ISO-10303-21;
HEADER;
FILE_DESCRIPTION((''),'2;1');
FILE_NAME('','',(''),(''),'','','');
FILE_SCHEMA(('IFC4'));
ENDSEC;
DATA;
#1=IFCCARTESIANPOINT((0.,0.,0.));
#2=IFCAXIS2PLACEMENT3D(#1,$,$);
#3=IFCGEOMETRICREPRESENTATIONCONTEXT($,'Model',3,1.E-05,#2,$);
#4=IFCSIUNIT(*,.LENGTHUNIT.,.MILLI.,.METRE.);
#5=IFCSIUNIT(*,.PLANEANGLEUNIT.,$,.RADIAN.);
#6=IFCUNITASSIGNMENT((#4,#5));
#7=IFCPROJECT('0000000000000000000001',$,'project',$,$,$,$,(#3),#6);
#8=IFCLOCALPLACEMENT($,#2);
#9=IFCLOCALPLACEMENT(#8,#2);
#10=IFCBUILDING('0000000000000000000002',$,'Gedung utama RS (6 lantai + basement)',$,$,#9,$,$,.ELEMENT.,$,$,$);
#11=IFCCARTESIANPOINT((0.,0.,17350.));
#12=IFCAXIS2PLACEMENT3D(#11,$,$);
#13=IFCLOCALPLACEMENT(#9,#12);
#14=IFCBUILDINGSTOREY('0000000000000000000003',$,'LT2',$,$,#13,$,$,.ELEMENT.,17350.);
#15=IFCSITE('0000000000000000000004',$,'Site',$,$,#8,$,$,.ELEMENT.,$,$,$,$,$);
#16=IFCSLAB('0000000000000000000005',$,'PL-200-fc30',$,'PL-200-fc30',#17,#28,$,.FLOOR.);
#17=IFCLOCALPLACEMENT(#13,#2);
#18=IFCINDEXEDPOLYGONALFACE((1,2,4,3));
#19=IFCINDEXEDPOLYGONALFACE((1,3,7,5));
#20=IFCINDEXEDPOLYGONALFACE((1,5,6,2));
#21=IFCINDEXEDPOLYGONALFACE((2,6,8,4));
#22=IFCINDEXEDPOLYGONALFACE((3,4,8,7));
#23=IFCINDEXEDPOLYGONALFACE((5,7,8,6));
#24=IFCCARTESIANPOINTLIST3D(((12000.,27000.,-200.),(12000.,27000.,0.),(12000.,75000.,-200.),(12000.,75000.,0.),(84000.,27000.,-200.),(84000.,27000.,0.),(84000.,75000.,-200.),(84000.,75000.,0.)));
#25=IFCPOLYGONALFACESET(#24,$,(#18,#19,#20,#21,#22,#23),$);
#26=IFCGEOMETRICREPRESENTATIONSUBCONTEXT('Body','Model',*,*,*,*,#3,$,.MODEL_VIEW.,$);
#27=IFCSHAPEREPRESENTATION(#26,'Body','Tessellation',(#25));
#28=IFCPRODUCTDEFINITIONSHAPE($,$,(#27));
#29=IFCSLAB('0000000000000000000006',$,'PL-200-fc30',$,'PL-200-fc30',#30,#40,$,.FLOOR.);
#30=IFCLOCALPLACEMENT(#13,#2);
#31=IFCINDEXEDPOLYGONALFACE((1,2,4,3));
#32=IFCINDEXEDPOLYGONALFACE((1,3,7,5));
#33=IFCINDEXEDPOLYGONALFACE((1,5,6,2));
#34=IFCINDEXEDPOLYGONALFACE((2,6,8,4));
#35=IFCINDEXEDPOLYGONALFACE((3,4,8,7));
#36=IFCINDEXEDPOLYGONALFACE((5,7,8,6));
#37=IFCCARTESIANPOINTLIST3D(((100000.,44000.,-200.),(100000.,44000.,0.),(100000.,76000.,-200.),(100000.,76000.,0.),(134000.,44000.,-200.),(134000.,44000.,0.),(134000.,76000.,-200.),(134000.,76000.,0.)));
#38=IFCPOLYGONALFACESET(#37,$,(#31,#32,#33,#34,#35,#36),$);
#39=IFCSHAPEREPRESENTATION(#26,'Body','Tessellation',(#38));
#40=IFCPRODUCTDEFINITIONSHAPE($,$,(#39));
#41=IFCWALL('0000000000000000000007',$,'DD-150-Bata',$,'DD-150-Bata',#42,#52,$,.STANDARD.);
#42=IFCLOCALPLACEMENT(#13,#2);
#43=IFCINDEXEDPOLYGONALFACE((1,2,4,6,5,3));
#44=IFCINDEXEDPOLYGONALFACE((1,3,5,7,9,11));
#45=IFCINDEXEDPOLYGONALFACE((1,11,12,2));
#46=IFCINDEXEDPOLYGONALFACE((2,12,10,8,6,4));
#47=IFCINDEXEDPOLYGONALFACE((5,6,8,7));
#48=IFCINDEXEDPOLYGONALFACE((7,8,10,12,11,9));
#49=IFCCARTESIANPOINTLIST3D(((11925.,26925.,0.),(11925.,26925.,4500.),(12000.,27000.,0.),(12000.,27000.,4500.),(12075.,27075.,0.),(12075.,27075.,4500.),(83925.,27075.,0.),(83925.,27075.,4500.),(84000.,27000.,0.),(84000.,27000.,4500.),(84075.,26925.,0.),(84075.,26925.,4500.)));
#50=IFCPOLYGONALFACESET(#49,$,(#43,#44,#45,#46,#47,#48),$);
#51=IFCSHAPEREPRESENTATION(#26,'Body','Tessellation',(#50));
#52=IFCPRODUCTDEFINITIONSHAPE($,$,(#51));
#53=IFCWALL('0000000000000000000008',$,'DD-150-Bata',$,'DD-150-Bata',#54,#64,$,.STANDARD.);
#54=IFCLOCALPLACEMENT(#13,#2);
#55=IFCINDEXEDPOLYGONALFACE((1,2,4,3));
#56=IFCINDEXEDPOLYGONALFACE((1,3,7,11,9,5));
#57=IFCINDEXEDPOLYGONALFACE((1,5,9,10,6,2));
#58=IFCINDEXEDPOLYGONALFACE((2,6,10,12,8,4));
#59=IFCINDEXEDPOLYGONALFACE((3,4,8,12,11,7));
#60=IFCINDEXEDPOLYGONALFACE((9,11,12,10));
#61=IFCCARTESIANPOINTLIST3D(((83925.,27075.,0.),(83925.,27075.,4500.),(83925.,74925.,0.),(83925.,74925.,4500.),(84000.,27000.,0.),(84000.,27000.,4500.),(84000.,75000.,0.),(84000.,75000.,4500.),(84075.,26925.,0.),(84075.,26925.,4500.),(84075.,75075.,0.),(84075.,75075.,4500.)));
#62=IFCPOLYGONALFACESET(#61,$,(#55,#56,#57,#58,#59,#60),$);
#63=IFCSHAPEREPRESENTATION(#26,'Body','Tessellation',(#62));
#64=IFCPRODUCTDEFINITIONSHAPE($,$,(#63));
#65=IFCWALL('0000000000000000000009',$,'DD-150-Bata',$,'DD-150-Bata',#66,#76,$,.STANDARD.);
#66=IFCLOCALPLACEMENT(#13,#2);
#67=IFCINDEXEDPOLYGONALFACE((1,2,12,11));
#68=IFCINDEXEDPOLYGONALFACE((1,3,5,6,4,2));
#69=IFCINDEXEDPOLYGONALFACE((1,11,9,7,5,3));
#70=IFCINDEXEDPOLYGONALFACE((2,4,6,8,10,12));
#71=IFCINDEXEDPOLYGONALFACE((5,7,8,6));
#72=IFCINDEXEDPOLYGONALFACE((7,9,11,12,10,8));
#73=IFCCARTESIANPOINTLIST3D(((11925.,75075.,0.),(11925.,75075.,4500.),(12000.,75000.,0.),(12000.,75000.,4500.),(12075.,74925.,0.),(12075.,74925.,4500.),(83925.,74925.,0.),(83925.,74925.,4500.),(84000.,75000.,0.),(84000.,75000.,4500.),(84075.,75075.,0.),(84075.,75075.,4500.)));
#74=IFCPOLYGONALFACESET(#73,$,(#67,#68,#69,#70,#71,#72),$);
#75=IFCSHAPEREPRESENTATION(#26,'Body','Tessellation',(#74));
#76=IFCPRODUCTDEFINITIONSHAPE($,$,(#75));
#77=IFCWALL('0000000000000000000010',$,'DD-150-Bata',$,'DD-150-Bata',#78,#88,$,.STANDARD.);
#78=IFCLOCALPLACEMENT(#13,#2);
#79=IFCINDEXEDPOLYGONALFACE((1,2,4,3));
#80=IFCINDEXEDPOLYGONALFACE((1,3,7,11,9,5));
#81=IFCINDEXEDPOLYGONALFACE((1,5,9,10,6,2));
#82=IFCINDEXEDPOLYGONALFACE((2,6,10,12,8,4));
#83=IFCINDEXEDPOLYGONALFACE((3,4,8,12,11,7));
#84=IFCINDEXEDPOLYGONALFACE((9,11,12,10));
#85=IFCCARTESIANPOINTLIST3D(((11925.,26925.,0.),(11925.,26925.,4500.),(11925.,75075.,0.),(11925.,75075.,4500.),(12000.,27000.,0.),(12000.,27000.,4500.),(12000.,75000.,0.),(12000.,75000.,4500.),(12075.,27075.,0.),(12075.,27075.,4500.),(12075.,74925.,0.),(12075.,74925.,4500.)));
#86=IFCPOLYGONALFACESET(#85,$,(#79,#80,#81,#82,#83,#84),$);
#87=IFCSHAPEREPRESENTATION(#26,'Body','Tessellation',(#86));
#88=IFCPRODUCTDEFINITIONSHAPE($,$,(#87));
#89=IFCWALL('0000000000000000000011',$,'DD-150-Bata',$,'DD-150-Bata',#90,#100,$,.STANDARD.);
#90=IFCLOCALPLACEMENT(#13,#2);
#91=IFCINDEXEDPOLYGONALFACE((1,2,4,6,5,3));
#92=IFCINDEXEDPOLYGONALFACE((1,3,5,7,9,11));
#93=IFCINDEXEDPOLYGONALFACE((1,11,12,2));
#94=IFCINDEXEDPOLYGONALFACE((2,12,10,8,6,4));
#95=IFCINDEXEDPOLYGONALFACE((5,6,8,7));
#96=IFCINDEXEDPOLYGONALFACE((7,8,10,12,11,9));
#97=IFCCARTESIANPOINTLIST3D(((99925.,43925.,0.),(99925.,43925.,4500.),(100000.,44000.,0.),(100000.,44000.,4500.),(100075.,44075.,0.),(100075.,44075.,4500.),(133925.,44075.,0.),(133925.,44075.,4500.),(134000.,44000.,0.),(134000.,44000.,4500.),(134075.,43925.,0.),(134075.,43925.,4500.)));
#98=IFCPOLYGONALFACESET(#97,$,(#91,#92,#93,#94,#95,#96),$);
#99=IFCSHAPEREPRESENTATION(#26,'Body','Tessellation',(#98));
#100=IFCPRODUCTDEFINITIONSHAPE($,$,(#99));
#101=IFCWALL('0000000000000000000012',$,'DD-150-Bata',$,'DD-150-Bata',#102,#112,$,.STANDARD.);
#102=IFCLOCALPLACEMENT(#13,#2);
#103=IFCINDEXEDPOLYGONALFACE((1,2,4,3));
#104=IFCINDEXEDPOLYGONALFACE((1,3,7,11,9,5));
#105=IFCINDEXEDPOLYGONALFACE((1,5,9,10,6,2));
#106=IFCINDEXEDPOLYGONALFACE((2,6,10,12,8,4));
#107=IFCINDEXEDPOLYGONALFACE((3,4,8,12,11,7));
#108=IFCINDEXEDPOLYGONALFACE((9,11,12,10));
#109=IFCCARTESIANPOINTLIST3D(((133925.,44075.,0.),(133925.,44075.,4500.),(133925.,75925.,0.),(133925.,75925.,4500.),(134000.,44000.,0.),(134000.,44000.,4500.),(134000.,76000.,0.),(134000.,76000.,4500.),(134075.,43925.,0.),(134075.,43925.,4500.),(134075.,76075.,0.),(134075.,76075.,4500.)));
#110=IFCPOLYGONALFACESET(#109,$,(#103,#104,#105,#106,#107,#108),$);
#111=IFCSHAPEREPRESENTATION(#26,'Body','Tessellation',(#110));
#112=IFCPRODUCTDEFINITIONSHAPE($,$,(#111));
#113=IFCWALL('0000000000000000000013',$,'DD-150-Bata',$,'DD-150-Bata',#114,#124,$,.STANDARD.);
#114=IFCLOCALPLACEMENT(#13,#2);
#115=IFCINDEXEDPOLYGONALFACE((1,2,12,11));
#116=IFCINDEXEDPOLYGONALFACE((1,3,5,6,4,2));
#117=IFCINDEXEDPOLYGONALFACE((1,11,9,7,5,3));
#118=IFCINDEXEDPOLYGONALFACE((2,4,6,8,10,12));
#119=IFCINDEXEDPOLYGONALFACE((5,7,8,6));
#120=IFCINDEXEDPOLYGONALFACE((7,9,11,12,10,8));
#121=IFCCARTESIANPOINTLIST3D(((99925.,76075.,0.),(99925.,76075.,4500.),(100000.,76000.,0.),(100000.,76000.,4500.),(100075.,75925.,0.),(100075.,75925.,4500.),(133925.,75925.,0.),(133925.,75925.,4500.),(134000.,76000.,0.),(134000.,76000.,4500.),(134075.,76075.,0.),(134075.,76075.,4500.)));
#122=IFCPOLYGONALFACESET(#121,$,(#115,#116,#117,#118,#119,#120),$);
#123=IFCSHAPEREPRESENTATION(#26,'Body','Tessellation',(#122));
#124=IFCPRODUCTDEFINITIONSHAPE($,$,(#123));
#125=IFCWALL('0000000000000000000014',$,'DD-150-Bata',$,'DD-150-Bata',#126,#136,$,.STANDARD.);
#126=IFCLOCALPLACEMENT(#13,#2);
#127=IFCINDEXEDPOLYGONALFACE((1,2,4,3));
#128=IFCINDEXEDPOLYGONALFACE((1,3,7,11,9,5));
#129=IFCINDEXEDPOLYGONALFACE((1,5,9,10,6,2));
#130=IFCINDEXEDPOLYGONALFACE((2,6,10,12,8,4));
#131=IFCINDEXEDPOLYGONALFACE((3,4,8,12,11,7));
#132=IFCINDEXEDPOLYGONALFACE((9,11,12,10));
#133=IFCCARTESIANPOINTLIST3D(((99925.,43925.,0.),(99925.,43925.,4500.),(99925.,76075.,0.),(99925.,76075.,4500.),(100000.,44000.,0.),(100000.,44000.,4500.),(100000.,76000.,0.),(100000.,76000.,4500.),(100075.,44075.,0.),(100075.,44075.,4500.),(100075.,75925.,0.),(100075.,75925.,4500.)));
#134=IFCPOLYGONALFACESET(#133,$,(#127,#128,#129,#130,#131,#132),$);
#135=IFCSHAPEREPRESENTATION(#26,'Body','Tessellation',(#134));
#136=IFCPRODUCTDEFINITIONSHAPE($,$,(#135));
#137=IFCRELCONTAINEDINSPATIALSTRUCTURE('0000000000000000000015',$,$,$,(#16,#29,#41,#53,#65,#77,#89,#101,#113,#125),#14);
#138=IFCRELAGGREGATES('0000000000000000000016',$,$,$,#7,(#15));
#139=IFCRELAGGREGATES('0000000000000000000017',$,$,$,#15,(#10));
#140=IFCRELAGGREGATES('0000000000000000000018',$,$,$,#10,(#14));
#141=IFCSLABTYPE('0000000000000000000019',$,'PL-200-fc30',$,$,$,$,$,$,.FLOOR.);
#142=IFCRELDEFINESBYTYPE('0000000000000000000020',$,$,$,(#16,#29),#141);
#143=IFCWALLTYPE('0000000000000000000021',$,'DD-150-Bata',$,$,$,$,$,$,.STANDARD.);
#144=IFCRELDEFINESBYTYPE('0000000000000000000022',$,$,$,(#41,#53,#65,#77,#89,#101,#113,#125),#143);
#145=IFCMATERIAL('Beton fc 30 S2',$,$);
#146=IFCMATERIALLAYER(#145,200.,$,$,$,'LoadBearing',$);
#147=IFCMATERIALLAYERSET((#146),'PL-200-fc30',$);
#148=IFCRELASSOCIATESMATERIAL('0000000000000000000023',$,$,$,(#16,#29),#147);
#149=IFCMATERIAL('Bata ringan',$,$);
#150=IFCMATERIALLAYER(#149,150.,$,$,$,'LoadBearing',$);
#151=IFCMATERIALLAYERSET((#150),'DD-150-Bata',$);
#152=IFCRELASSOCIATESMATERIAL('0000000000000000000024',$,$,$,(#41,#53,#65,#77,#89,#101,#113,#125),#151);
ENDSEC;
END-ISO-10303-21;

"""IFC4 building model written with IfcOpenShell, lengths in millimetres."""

from ifc_helpers import new_model, si_unit, frame, origin, place, context, subcontext, project, spatial, polyline, outline, extrude, material, layer, layer_set, layer_usage, type_object, element, save


model = new_model("IFC4")

# Units and contexts
model_context = context("Model", 3, precision=1e-05, world=origin())
body_context = subcontext(model_context, "Body", "Model", "MODEL_VIEW")
ifc_project = project(units=[si_unit("LENGTHUNIT", "METRE", prefix="MILLI"), si_unit("PLANEANGLEUNIT", "RADIAN")], contexts=[model_context])

# Site, building, storey
site_placement = place(None, origin())
site = spatial("IfcSite", under=ifc_project, at=site_placement, Name="Site", CompositionType="ELEMENT")
building_placement = place(site_placement, origin())
building = spatial("IfcBuilding", under=site, at=building_placement, Name="Gedung utama RS (6 lantai + basement)", CompositionType="ELEMENT")
storey_placement = place(building_placement, frame((0.0, 0.0, 17350.0)))
storey = spatial("IfcBuildingStorey", under=building, at=storey_placement, Name="LT2", CompositionType="ELEMENT", Elevation=17350.0)

# Slabs
ifc_material_1 = material(Name="Beton fc 30 S2")
ifc_layer_1 = layer(ifc_material_1, 200.0, Category="LoadBearing")
ifc_layer_set_1 = layer_set([ifc_layer_1], Name="PL-200-fc30")
ifc_layer_usage_1 = layer_usage(ifc_layer_set_1, "AXIS3", "NEGATIVE", 0.0)
slab_type = type_object("IfcSlabType", Name="PL-200-fc30", PredefinedType="FLOOR")
slab_1_placement = place(storey_placement, origin())
element("IfcSlab", 1, at=slab_1_placement, inside=storey, type_object=slab_type, material=ifc_layer_usage_1, Name="PL-200-fc30", ObjectType="PL-200-fc30", PredefinedType="FLOOR", context=body_context, shape_type="SweptSolid", body=[
    extrude(outline(polyline([(12000.0, 27000.0), (84000.0, 27000.0), (84000.0, 75000.0), (12000.0, 75000.0), (12000.0, 27000.0)])), frame((0.0, 0.0, -200.0)), (0.0, 0.0, 1.0), 200.0),
])
slab_2_placement = place(storey_placement, origin())
element("IfcSlab", 2, at=slab_2_placement, inside=storey, type_object=slab_type, material=ifc_layer_usage_1, Name="PL-200-fc30", ObjectType="PL-200-fc30", PredefinedType="FLOOR", context=body_context, shape_type="SweptSolid", body=[
    extrude(outline(polyline([(100000.0, 44000.0), (134000.0, 44000.0), (134000.0, 76000.0), (100000.0, 76000.0), (100000.0, 44000.0)])), frame((0.0, 0.0, -200.0)), (0.0, 0.0, 1.0), 200.0),
])

# Walls
ifc_material_2 = material(Name="Bata ringan")
ifc_layer_2 = layer(ifc_material_2, 150.0, Category="LoadBearing")
ifc_layer_set_2 = layer_set([ifc_layer_2], Name="DD-150-Bata")
ifc_layer_usage_2 = layer_usage(ifc_layer_set_2, "AXIS2", "NEGATIVE", 75.0)
wall_type = type_object("IfcWallType", Name="DD-150-Bata", PredefinedType="STANDARD")
wall_1_placement = place(storey_placement, frame((12000.0, 27000.0, 0.0), z_axis=(0.0, 0.0, 1.0), x_axis=(1.0, 0.0, 0.0)))
element("IfcWall", 3, at=wall_1_placement, inside=storey, type_object=wall_type, material=ifc_layer_usage_2, Name="DD-150-Bata", ObjectType="DD-150-Bata", PredefinedType="STANDARD", context=body_context, shape_type="SweptSolid", body=[
    extrude(outline(polyline([(-75.0, -75.0), (0.0, 0.0), (75.0, 75.0), (71925.0, 75.0), (72000.0, 0.0), (72075.0, -75.0), (-75.0, -75.0)])), origin(), (0.0, 0.0, 1.0), 4500.0),
])
wall_2_placement = place(storey_placement, frame((84000.0, 27000.0, 0.0), z_axis=(0.0, 0.0, 1.0), x_axis=(0.0, 1.0, 0.0)))
element("IfcWall", 4, at=wall_2_placement, inside=storey, type_object=wall_type, material=ifc_layer_usage_2, Name="DD-150-Bata", ObjectType="DD-150-Bata", PredefinedType="STANDARD", context=body_context, shape_type="SweptSolid", body=[
    extrude(outline(polyline([(-75.0, -75.0), (0.0, 0.0), (75.0, 75.0), (47925.0, 75.0), (48000.0, 0.0), (48075.0, -75.0), (-75.0, -75.0)])), origin(), (0.0, 0.0, 1.0), 4500.0),
])
wall_3_placement = place(storey_placement, frame((84000.0, 75000.0, 0.0), z_axis=(0.0, 0.0, 1.0), x_axis=(-1.0, 0.0, 0.0)))
element("IfcWall", 5, at=wall_3_placement, inside=storey, type_object=wall_type, material=ifc_layer_usage_2, Name="DD-150-Bata", ObjectType="DD-150-Bata", PredefinedType="STANDARD", context=body_context, shape_type="SweptSolid", body=[
    extrude(outline(polyline([(-75.0, -75.0), (0.0, 0.0), (75.0, 75.0), (71925.0, 75.0), (72000.0, 0.0), (72075.0, -75.0), (-75.0, -75.0)])), origin(), (0.0, 0.0, 1.0), 4500.0),
])
wall_4_placement = place(storey_placement, frame((12000.0, 75000.0, 0.0), z_axis=(0.0, 0.0, 1.0), x_axis=(0.0, -1.0, 0.0)))
element("IfcWall", 6, at=wall_4_placement, inside=storey, type_object=wall_type, material=ifc_layer_usage_2, Name="DD-150-Bata", ObjectType="DD-150-Bata", PredefinedType="STANDARD", context=body_context, shape_type="SweptSolid", body=[
    extrude(outline(polyline([(-75.0, -75.0), (0.0, 0.0), (75.0, 75.0), (47925.0, 75.0), (48000.0, 0.0), (48075.0, -75.0), (-75.0, -75.0)])), origin(), (0.0, 0.0, 1.0), 4500.0),
])
wall_5_placement = place(storey_placement, frame((100000.0, 44000.0, 0.0), z_axis=(0.0, 0.0, 1.0), x_axis=(1.0, 0.0, 0.0)))
element("IfcWall", 7, at=wall_5_placement, inside=storey, type_object=wall_type, material=ifc_layer_usage_2, Name="DD-150-Bata", ObjectType="DD-150-Bata", PredefinedType="STANDARD", context=body_context, shape_type="SweptSolid", body=[
    extrude(outline(polyline([(-75.0, -75.0), (0.0, 0.0), (75.0, 75.0), (33925.0, 75.0), (34000.0, 0.0), (34075.0, -75.0), (-75.0, -75.0)])), origin(), (0.0, 0.0, 1.0), 4500.0),
])
wall_6_placement = place(storey_placement, frame((134000.0, 44000.0, 0.0), z_axis=(0.0, 0.0, 1.0), x_axis=(0.0, 1.0, 0.0)))
element("IfcWall", 8, at=wall_6_placement, inside=storey, type_object=wall_type, material=ifc_layer_usage_2, Name="DD-150-Bata", ObjectType="DD-150-Bata", PredefinedType="STANDARD", context=body_context, shape_type="SweptSolid", body=[
    extrude(outline(polyline([(-75.0, -75.0), (0.0, 0.0), (75.0, 75.0), (31925.0, 75.0), (32000.0, 0.0), (32075.0, -75.0), (-75.0, -75.0)])), origin(), (0.0, 0.0, 1.0), 4500.0),
])
wall_7_placement = place(storey_placement, frame((134000.0, 76000.0, 0.0), z_axis=(0.0, 0.0, 1.0), x_axis=(-1.0, 0.0, 0.0)))
element("IfcWall", 9, at=wall_7_placement, inside=storey, type_object=wall_type, material=ifc_layer_usage_2, Name="DD-150-Bata", ObjectType="DD-150-Bata", PredefinedType="STANDARD", context=body_context, shape_type="SweptSolid", body=[
    extrude(outline(polyline([(-75.0, -75.0), (0.0, 0.0), (75.0, 75.0), (33925.0, 75.0), (34000.0, 0.0), (34075.0, -75.0), (-75.0, -75.0)])), origin(), (0.0, 0.0, 1.0), 4500.0),
])
wall_8_placement = place(storey_placement, frame((100000.0, 76000.0, 0.0), z_axis=(0.0, 0.0, 1.0), x_axis=(0.0, -1.0, 0.0)))
element("IfcWall", 10, at=wall_8_placement, inside=storey, type_object=wall_type, material=ifc_layer_usage_2, Name="DD-150-Bata", ObjectType="DD-150-Bata", PredefinedType="STANDARD", context=body_context, shape_type="SweptSolid", body=[
    extrude(outline(polyline([(-75.0, -75.0), (0.0, 0.0), (75.0, 75.0), (31925.0, 75.0), (32000.0, 0.0), (32075.0, -75.0), (-75.0, -75.0)])), origin(), (0.0, 0.0, 1.0), 4500.0),
])

save(model, "model.ifc")
